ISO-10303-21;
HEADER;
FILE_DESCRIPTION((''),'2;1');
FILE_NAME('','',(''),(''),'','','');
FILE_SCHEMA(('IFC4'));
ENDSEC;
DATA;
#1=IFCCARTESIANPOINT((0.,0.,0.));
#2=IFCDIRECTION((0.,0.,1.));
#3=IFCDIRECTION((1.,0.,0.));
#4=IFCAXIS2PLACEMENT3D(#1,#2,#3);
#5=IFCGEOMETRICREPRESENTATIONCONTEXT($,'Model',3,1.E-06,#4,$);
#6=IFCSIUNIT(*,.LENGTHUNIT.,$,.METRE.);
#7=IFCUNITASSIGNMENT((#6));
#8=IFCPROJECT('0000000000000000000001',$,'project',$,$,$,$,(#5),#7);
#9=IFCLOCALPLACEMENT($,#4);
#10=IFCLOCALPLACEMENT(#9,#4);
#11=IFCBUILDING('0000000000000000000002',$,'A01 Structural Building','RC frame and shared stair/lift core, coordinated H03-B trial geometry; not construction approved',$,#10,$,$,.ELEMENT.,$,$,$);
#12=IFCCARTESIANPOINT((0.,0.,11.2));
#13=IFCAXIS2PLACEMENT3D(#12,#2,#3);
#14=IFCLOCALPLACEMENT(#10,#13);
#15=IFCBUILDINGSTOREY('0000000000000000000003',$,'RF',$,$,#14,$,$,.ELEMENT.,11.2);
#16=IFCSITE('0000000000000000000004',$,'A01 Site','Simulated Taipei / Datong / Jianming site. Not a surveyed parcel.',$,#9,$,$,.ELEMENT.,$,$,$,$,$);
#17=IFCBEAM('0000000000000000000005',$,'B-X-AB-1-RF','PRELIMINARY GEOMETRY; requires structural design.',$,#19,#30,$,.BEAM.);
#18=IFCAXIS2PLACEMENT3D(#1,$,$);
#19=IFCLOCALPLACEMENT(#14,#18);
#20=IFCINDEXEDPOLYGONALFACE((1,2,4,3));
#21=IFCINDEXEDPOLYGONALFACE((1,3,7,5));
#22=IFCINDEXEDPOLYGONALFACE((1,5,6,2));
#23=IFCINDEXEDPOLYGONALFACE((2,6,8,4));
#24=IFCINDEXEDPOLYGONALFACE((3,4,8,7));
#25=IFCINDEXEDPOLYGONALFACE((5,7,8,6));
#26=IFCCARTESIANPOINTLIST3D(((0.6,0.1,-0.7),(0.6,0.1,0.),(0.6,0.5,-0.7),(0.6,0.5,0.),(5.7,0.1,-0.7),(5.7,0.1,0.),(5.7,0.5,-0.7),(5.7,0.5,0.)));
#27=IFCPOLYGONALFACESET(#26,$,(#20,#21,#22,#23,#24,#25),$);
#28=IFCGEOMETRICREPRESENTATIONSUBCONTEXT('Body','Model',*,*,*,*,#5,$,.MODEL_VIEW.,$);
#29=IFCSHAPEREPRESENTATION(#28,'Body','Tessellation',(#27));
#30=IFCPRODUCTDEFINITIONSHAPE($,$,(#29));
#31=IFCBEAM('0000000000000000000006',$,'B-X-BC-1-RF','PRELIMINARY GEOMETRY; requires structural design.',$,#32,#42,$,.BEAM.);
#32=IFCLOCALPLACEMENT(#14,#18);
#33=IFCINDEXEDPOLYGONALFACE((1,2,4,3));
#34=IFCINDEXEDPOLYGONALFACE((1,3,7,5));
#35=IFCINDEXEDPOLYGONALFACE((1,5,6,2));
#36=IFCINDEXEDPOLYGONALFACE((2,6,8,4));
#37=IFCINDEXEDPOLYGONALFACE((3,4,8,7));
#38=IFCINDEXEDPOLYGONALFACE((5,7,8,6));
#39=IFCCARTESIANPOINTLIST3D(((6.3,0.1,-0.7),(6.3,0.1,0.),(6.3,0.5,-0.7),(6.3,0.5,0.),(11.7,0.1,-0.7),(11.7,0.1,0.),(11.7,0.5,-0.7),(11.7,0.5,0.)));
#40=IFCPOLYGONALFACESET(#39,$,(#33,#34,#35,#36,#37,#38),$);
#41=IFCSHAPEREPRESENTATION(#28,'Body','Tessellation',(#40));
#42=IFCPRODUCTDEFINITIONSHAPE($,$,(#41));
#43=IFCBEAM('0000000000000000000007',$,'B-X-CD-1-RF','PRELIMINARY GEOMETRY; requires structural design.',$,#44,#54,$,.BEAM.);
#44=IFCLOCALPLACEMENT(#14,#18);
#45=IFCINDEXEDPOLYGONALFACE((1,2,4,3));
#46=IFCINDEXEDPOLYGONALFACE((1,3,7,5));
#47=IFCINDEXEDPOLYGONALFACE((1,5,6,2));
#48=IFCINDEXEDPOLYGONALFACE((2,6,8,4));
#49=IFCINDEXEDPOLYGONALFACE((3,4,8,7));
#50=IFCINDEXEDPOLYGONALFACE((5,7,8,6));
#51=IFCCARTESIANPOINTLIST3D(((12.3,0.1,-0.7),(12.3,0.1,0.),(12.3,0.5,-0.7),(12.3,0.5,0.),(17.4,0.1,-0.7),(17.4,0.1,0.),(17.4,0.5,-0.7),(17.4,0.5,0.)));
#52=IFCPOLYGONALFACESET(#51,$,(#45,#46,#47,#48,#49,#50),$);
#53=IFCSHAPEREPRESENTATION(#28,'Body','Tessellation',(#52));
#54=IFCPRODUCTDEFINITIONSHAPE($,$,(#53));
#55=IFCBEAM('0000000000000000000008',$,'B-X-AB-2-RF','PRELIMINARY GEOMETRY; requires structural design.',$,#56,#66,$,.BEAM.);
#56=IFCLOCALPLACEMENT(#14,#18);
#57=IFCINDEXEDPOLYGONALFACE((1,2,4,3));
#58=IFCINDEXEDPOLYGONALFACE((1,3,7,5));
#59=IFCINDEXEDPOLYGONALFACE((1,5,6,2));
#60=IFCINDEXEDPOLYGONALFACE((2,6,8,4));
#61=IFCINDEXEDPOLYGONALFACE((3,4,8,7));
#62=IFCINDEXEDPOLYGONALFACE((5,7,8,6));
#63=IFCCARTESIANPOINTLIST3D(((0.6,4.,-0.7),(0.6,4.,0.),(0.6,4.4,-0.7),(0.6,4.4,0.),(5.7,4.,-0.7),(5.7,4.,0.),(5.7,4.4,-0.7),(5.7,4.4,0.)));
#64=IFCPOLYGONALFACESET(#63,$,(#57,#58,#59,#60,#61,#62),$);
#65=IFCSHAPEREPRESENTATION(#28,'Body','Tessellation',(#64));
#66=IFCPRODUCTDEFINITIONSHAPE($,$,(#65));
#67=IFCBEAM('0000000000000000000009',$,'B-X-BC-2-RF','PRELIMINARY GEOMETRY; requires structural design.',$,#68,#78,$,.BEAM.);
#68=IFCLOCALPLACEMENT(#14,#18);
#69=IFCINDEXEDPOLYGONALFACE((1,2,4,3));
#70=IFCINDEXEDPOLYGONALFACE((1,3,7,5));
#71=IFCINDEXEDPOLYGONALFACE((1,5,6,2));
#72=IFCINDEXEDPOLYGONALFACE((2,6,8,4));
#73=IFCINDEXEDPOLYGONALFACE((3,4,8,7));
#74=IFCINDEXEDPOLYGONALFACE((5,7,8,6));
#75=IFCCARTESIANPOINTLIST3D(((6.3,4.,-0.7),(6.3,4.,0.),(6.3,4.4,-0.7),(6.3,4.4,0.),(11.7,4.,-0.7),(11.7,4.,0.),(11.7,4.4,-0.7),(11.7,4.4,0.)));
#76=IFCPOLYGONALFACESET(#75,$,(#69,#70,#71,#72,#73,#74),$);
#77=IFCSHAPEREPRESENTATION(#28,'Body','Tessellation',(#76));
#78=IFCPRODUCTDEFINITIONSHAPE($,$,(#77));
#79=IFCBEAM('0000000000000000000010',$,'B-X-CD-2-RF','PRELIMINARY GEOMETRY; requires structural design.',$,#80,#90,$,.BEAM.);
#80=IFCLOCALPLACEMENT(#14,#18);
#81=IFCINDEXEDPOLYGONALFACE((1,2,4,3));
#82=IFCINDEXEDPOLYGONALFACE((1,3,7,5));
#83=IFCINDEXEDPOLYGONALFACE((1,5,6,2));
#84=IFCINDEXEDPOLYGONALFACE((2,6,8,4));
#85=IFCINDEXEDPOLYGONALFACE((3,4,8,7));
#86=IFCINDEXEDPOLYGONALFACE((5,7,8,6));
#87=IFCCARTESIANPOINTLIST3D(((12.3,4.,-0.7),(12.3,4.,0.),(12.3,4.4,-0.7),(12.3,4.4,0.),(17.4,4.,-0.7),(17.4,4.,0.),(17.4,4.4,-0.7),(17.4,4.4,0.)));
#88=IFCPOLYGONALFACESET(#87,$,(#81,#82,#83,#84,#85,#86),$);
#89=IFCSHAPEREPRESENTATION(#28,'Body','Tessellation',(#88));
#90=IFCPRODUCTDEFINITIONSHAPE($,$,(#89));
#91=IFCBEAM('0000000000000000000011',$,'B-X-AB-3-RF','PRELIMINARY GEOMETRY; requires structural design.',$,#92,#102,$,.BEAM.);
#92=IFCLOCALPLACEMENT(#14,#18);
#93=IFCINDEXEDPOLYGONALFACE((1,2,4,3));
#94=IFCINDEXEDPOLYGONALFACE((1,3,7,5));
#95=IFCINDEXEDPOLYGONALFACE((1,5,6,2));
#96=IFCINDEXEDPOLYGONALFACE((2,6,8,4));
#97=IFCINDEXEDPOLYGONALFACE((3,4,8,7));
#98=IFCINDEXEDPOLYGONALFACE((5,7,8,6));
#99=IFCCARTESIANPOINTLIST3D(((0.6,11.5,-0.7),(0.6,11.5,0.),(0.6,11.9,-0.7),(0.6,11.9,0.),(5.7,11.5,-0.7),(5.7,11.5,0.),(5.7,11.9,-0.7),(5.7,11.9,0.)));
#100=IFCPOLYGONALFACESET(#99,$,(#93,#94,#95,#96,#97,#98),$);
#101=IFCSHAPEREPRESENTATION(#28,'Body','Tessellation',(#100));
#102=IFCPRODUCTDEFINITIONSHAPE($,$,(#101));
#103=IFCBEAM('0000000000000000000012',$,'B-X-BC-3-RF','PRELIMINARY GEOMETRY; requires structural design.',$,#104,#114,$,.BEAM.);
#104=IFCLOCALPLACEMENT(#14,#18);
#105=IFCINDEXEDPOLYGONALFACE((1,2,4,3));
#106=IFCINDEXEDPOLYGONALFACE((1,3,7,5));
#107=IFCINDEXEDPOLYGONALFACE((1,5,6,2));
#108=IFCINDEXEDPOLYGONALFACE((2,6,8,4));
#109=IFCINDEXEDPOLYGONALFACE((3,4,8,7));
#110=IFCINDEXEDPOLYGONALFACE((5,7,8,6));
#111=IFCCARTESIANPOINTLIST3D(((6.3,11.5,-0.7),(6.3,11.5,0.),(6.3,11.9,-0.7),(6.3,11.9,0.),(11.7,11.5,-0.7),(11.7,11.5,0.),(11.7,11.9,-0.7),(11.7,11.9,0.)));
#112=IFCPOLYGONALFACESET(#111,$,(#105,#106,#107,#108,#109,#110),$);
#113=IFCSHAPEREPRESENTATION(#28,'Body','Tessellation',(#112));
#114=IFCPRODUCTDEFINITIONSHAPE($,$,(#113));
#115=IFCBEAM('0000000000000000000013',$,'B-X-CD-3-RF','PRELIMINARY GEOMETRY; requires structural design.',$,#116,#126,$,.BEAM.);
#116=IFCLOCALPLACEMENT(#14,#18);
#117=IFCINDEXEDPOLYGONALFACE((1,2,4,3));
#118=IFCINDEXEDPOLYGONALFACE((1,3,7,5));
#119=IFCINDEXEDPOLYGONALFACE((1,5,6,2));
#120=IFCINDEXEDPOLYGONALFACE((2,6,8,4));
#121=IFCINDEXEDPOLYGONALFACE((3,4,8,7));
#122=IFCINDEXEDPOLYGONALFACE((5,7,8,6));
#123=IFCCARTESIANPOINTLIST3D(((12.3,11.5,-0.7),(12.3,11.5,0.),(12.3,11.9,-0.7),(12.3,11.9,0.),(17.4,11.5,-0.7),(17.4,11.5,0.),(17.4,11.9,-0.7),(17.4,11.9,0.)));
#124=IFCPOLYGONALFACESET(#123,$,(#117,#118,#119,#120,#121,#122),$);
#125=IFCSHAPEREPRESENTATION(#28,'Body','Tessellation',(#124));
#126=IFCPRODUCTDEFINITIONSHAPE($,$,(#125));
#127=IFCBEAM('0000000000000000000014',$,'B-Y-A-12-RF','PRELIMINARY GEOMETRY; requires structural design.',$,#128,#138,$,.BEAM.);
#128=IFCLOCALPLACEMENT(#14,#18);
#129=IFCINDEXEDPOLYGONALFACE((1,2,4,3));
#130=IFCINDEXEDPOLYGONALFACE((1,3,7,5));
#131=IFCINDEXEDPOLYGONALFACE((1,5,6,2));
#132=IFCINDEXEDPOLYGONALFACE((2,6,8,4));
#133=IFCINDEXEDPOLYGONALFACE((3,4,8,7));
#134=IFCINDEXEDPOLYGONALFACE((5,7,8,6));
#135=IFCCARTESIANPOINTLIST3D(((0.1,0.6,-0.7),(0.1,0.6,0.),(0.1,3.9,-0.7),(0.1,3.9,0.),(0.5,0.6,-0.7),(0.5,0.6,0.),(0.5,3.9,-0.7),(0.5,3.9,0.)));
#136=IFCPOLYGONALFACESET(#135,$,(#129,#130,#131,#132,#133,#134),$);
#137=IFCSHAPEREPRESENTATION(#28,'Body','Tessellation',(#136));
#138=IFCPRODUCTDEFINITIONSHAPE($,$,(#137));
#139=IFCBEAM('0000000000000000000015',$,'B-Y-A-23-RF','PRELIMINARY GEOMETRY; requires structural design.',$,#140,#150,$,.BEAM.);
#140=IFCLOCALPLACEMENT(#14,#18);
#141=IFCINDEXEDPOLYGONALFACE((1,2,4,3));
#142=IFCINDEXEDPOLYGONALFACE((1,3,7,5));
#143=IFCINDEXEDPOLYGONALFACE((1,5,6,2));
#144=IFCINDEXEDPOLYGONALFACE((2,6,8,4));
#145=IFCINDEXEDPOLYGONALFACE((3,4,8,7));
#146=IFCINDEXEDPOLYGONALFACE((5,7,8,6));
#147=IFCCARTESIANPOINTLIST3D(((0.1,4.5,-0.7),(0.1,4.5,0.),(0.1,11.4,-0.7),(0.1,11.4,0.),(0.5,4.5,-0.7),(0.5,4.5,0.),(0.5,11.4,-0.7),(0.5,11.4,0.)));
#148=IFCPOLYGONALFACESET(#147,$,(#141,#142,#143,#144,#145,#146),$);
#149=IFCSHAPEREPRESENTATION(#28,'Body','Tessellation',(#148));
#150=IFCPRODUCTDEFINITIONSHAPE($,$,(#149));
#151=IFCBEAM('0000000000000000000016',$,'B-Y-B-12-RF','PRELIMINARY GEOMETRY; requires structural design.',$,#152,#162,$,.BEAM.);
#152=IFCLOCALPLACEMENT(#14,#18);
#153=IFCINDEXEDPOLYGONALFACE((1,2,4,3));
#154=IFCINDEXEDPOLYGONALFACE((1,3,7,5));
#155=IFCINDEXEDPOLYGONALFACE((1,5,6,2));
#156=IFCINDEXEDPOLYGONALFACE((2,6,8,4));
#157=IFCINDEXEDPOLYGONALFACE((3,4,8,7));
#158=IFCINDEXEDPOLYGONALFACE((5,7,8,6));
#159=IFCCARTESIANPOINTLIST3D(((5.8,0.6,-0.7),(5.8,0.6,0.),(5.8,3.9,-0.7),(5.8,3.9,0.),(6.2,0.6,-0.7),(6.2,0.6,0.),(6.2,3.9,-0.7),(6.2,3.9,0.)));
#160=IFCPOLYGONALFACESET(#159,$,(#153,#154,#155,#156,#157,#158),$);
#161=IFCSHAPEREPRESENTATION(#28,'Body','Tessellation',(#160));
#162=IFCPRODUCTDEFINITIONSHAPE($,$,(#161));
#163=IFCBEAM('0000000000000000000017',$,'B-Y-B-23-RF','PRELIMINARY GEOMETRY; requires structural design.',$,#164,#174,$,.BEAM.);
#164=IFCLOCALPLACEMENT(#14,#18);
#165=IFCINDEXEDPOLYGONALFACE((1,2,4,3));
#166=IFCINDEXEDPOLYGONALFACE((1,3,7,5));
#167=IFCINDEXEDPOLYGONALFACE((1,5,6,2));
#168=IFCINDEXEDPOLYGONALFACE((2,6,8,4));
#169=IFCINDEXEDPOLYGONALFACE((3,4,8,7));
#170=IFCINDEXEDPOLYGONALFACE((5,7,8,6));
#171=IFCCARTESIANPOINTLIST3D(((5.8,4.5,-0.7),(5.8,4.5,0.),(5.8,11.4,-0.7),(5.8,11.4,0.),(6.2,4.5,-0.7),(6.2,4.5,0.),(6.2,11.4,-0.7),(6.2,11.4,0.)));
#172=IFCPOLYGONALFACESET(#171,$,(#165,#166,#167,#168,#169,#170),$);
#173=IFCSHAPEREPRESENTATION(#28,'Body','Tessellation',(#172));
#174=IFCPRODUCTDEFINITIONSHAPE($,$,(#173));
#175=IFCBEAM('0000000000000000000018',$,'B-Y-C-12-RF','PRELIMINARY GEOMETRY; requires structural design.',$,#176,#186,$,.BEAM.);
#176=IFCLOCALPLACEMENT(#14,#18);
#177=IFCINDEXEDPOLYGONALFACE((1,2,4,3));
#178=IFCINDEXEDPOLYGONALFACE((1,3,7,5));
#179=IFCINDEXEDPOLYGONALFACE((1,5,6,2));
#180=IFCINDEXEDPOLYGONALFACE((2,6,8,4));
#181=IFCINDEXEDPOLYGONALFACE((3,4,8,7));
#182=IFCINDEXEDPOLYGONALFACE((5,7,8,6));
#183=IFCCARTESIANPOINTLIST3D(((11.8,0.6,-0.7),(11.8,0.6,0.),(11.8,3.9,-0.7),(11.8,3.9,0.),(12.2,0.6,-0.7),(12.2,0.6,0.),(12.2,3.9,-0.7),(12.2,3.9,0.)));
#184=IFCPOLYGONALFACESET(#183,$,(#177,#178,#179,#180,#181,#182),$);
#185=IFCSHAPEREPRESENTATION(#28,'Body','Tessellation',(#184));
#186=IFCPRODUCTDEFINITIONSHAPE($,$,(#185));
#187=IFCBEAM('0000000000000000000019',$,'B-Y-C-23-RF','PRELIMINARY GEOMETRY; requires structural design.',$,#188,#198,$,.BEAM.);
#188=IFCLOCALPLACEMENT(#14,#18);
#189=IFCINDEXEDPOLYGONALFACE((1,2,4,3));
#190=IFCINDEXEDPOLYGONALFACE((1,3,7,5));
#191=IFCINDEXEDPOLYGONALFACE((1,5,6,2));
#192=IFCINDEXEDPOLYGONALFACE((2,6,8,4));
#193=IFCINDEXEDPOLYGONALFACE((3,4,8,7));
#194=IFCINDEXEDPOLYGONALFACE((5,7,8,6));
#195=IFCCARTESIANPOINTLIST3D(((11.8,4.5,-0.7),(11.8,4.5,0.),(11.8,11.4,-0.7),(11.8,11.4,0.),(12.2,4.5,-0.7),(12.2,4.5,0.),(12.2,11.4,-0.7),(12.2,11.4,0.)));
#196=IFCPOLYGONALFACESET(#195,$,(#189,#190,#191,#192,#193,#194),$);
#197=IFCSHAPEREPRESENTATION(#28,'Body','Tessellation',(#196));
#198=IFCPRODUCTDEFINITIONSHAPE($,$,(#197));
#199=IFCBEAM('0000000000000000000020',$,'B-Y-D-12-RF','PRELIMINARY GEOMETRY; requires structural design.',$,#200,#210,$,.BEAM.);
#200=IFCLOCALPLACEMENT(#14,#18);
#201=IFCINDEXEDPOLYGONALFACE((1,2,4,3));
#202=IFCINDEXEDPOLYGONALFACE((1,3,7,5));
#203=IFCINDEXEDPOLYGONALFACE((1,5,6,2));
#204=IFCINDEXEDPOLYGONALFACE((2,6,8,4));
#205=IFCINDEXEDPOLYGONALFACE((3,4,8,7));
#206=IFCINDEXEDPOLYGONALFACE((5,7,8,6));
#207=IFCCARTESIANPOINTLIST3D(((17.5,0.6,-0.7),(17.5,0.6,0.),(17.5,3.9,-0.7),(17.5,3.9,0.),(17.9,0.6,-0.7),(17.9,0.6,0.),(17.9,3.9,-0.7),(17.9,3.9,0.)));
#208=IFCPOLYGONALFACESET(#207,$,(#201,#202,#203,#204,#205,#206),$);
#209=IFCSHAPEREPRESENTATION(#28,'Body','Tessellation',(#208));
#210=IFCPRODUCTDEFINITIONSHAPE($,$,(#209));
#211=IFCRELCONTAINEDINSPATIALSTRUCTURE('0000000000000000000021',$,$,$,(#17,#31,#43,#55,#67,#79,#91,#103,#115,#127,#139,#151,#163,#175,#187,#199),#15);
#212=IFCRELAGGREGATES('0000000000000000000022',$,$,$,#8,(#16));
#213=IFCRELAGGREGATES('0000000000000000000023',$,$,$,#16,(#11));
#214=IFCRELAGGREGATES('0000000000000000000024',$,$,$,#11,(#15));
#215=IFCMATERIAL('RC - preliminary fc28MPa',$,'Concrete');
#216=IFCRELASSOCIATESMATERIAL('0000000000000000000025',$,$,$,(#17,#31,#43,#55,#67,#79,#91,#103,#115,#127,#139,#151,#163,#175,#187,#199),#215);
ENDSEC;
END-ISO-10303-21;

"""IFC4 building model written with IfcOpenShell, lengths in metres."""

from ifc_helpers import new_model, si_unit, frame, origin_with_axes, place, context, subcontext, project, spatial, rectangle, extrude, material, element, save


model = new_model("IFC4")

# Units and contexts
model_context = context("Model", 3, precision=1e-06, world=origin_with_axes())
body_context = subcontext(model_context, "Body", "Model", "MODEL_VIEW")
ifc_project = project(units=[si_unit("LENGTHUNIT", "METRE")], contexts=[model_context])

# Site, building, storey
site_placement = place(None, origin_with_axes())
site = spatial("IfcSite", under=ifc_project, at=site_placement, Name="A01 Site", Description="Simulated Taipei / Datong / Jianming site. Not a surveyed parcel.", CompositionType="ELEMENT")
building_placement = place(site_placement, origin_with_axes())
building = spatial("IfcBuilding", under=site, at=building_placement, Name="A01 Structural Building", Description="RC frame and shared stair/lift core, coordinated H03-B trial geometry; not construction approved", CompositionType="ELEMENT")
storey_placement = place(building_placement, frame((0.0, 0.0, 11.2), z_axis=(0.0, 0.0, 1.0), x_axis=(1.0, 0.0, 0.0)))
storey = spatial("IfcBuildingStorey", under=building, at=storey_placement, Name="RF", CompositionType="ELEMENT", Elevation=11.2)

# Beams
ifc_material = material(Name="RC - preliminary fc28MPa", Category="Concrete")
beam_1_placement = place(storey_placement, frame((3.15, 0.3, -0.7), z_axis=(0.0, 0.0, 1.0), x_axis=(1.0, 0.0, 0.0)))
element("IfcBeam", 1, at=beam_1_placement, inside=storey, material=ifc_material, Name="B-X-AB-1-RF", Description="PRELIMINARY GEOMETRY; requires structural design.", PredefinedType="BEAM", context=body_context, shape_type="SweptSolid", body=[
    extrude(rectangle(XDim=5.1, YDim=0.4), origin_with_axes(), (0.0, 0.0, 1.0), 0.7),
])
beam_2_placement = place(storey_placement, frame((9.0, 0.3, -0.7), z_axis=(0.0, 0.0, 1.0), x_axis=(1.0, 0.0, 0.0)))
element("IfcBeam", 2, at=beam_2_placement, inside=storey, material=ifc_material, Name="B-X-BC-1-RF", Description="PRELIMINARY GEOMETRY; requires structural design.", PredefinedType="BEAM", context=body_context, shape_type="SweptSolid", body=[
    extrude(rectangle(XDim=5.4, YDim=0.4), origin_with_axes(), (0.0, 0.0, 1.0), 0.7),
])
for number, where, z_axis, x_axis, name in (
    (3, (14.85, 0.3, -0.7), (0.0, 0.0, 1.0), (1.0, 0.0, 0.0), "B-X-CD-1-RF"),
    (4, (3.15, 4.2, -0.7), (0.0, 0.0, 1.0), (1.0, 0.0, 0.0), "B-X-AB-2-RF"),
):
    element("IfcBeam", number, at=place(storey_placement, frame(where, z_axis=z_axis, x_axis=x_axis)), inside=storey, material=ifc_material, Name=name, Description="PRELIMINARY GEOMETRY; requires structural design.", PredefinedType="BEAM", context=body_context, shape_type="SweptSolid", body=[
        extrude(rectangle(XDim=5.1, YDim=0.4), origin_with_axes(), (0.0, 0.0, 1.0), 0.7),
    ])
beam_3_placement = place(storey_placement, frame((9.0, 4.2, -0.7), z_axis=(0.0, 0.0, 1.0), x_axis=(1.0, 0.0, 0.0)))
element("IfcBeam", 5, at=beam_3_placement, inside=storey, material=ifc_material, Name="B-X-BC-2-RF", Description="PRELIMINARY GEOMETRY; requires structural design.", PredefinedType="BEAM", context=body_context, shape_type="SweptSolid", body=[
    extrude(rectangle(XDim=5.4, YDim=0.4), origin_with_axes(), (0.0, 0.0, 1.0), 0.7),
])
for number, where, z_axis, x_axis, name in (
    (6, (14.85, 4.2, -0.7), (0.0, 0.0, 1.0), (1.0, 0.0, 0.0), "B-X-CD-2-RF"),
    (7, (3.15, 11.7, -0.7), (0.0, 0.0, 1.0), (1.0, 0.0, 0.0), "B-X-AB-3-RF"),
):
    element("IfcBeam", number, at=place(storey_placement, frame(where, z_axis=z_axis, x_axis=x_axis)), inside=storey, material=ifc_material, Name=name, Description="PRELIMINARY GEOMETRY; requires structural design.", PredefinedType="BEAM", context=body_context, shape_type="SweptSolid", body=[
        extrude(rectangle(XDim=5.1, YDim=0.4), origin_with_axes(), (0.0, 0.0, 1.0), 0.7),
    ])
beam_4_placement = place(storey_placement, frame((9.0, 11.7, -0.7), z_axis=(0.0, 0.0, 1.0), x_axis=(1.0, 0.0, 0.0)))
element("IfcBeam", 8, at=beam_4_placement, inside=storey, material=ifc_material, Name="B-X-BC-3-RF", Description="PRELIMINARY GEOMETRY; requires structural design.", PredefinedType="BEAM", context=body_context, shape_type="SweptSolid", body=[
    extrude(rectangle(XDim=5.4, YDim=0.4), origin_with_axes(), (0.0, 0.0, 1.0), 0.7),
])
beam_5_placement = place(storey_placement, frame((14.85, 11.7, -0.7), z_axis=(0.0, 0.0, 1.0), x_axis=(1.0, 0.0, 0.0)))
element("IfcBeam", 9, at=beam_5_placement, inside=storey, material=ifc_material, Name="B-X-CD-3-RF", Description="PRELIMINARY GEOMETRY; requires structural design.", PredefinedType="BEAM", context=body_context, shape_type="SweptSolid", body=[
    extrude(rectangle(XDim=5.1, YDim=0.4), origin_with_axes(), (0.0, 0.0, 1.0), 0.7),
])
beam_6_placement = place(storey_placement, frame((0.3, 2.25, -0.7), z_axis=(0.0, 0.0, 1.0), x_axis=(1.0, 0.0, 0.0)))
element("IfcBeam", 10, at=beam_6_placement, inside=storey, material=ifc_material, Name="B-Y-A-12-RF", Description="PRELIMINARY GEOMETRY; requires structural design.", PredefinedType="BEAM", context=body_context, shape_type="SweptSolid", body=[
    extrude(rectangle(XDim=0.4, YDim=3.3), origin_with_axes(), (0.0, 0.0, 1.0), 0.7),
])
beam_7_placement = place(storey_placement, frame((0.3, 7.95, -0.7), z_axis=(0.0, 0.0, 1.0), x_axis=(1.0, 0.0, 0.0)))
element("IfcBeam", 11, at=beam_7_placement, inside=storey, material=ifc_material, Name="B-Y-A-23-RF", Description="PRELIMINARY GEOMETRY; requires structural design.", PredefinedType="BEAM", context=body_context, shape_type="SweptSolid", body=[
    extrude(rectangle(XDim=0.4, YDim=6.9), origin_with_axes(), (0.0, 0.0, 1.0), 0.7),
])
beam_8_placement = place(storey_placement, frame((6.0, 2.25, -0.7), z_axis=(0.0, 0.0, 1.0), x_axis=(1.0, 0.0, 0.0)))
element("IfcBeam", 12, at=beam_8_placement, inside=storey, material=ifc_material, Name="B-Y-B-12-RF", Description="PRELIMINARY GEOMETRY; requires structural design.", PredefinedType="BEAM", context=body_context, shape_type="SweptSolid", body=[
    extrude(rectangle(XDim=0.4, YDim=3.3), origin_with_axes(), (0.0, 0.0, 1.0), 0.7),
])
beam_9_placement = place(storey_placement, frame((6.0, 7.95, -0.7), z_axis=(0.0, 0.0, 1.0), x_axis=(1.0, 0.0, 0.0)))
element("IfcBeam", 13, at=beam_9_placement, inside=storey, material=ifc_material, Name="B-Y-B-23-RF", Description="PRELIMINARY GEOMETRY; requires structural design.", PredefinedType="BEAM", context=body_context, shape_type="SweptSolid", body=[
    extrude(rectangle(XDim=0.4, YDim=6.9), origin_with_axes(), (0.0, 0.0, 1.0), 0.7),
])
beam_10_placement = place(storey_placement, frame((12.0, 2.25, -0.7), z_axis=(0.0, 0.0, 1.0), x_axis=(1.0, 0.0, 0.0)))
element("IfcBeam", 14, at=beam_10_placement, inside=storey, material=ifc_material, Name="B-Y-C-12-RF", Description="PRELIMINARY GEOMETRY; requires structural design.", PredefinedType="BEAM", context=body_context, shape_type="SweptSolid", body=[
    extrude(rectangle(XDim=0.4, YDim=3.3), origin_with_axes(), (0.0, 0.0, 1.0), 0.7),
])
beam_11_placement = place(storey_placement, frame((12.0, 7.95, -0.7), z_axis=(0.0, 0.0, 1.0), x_axis=(1.0, 0.0, 0.0)))
element("IfcBeam", 15, at=beam_11_placement, inside=storey, material=ifc_material, Name="B-Y-C-23-RF", Description="PRELIMINARY GEOMETRY; requires structural design.", PredefinedType="BEAM", context=body_context, shape_type="SweptSolid", body=[
    extrude(rectangle(XDim=0.4, YDim=6.9), origin_with_axes(), (0.0, 0.0, 1.0), 0.7),
])
beam_12_placement = place(storey_placement, frame((17.7, 2.25, -0.7), z_axis=(0.0, 0.0, 1.0), x_axis=(1.0, 0.0, 0.0)))
element("IfcBeam", 16, at=beam_12_placement, inside=storey, material=ifc_material, Name="B-Y-D-12-RF", Description="PRELIMINARY GEOMETRY; requires structural design.", PredefinedType="BEAM", context=body_context, shape_type="SweptSolid", body=[
    extrude(rectangle(XDim=0.4, YDim=3.3), origin_with_axes(), (0.0, 0.0, 1.0), 0.7),
])

save(model, "model.ifc")
